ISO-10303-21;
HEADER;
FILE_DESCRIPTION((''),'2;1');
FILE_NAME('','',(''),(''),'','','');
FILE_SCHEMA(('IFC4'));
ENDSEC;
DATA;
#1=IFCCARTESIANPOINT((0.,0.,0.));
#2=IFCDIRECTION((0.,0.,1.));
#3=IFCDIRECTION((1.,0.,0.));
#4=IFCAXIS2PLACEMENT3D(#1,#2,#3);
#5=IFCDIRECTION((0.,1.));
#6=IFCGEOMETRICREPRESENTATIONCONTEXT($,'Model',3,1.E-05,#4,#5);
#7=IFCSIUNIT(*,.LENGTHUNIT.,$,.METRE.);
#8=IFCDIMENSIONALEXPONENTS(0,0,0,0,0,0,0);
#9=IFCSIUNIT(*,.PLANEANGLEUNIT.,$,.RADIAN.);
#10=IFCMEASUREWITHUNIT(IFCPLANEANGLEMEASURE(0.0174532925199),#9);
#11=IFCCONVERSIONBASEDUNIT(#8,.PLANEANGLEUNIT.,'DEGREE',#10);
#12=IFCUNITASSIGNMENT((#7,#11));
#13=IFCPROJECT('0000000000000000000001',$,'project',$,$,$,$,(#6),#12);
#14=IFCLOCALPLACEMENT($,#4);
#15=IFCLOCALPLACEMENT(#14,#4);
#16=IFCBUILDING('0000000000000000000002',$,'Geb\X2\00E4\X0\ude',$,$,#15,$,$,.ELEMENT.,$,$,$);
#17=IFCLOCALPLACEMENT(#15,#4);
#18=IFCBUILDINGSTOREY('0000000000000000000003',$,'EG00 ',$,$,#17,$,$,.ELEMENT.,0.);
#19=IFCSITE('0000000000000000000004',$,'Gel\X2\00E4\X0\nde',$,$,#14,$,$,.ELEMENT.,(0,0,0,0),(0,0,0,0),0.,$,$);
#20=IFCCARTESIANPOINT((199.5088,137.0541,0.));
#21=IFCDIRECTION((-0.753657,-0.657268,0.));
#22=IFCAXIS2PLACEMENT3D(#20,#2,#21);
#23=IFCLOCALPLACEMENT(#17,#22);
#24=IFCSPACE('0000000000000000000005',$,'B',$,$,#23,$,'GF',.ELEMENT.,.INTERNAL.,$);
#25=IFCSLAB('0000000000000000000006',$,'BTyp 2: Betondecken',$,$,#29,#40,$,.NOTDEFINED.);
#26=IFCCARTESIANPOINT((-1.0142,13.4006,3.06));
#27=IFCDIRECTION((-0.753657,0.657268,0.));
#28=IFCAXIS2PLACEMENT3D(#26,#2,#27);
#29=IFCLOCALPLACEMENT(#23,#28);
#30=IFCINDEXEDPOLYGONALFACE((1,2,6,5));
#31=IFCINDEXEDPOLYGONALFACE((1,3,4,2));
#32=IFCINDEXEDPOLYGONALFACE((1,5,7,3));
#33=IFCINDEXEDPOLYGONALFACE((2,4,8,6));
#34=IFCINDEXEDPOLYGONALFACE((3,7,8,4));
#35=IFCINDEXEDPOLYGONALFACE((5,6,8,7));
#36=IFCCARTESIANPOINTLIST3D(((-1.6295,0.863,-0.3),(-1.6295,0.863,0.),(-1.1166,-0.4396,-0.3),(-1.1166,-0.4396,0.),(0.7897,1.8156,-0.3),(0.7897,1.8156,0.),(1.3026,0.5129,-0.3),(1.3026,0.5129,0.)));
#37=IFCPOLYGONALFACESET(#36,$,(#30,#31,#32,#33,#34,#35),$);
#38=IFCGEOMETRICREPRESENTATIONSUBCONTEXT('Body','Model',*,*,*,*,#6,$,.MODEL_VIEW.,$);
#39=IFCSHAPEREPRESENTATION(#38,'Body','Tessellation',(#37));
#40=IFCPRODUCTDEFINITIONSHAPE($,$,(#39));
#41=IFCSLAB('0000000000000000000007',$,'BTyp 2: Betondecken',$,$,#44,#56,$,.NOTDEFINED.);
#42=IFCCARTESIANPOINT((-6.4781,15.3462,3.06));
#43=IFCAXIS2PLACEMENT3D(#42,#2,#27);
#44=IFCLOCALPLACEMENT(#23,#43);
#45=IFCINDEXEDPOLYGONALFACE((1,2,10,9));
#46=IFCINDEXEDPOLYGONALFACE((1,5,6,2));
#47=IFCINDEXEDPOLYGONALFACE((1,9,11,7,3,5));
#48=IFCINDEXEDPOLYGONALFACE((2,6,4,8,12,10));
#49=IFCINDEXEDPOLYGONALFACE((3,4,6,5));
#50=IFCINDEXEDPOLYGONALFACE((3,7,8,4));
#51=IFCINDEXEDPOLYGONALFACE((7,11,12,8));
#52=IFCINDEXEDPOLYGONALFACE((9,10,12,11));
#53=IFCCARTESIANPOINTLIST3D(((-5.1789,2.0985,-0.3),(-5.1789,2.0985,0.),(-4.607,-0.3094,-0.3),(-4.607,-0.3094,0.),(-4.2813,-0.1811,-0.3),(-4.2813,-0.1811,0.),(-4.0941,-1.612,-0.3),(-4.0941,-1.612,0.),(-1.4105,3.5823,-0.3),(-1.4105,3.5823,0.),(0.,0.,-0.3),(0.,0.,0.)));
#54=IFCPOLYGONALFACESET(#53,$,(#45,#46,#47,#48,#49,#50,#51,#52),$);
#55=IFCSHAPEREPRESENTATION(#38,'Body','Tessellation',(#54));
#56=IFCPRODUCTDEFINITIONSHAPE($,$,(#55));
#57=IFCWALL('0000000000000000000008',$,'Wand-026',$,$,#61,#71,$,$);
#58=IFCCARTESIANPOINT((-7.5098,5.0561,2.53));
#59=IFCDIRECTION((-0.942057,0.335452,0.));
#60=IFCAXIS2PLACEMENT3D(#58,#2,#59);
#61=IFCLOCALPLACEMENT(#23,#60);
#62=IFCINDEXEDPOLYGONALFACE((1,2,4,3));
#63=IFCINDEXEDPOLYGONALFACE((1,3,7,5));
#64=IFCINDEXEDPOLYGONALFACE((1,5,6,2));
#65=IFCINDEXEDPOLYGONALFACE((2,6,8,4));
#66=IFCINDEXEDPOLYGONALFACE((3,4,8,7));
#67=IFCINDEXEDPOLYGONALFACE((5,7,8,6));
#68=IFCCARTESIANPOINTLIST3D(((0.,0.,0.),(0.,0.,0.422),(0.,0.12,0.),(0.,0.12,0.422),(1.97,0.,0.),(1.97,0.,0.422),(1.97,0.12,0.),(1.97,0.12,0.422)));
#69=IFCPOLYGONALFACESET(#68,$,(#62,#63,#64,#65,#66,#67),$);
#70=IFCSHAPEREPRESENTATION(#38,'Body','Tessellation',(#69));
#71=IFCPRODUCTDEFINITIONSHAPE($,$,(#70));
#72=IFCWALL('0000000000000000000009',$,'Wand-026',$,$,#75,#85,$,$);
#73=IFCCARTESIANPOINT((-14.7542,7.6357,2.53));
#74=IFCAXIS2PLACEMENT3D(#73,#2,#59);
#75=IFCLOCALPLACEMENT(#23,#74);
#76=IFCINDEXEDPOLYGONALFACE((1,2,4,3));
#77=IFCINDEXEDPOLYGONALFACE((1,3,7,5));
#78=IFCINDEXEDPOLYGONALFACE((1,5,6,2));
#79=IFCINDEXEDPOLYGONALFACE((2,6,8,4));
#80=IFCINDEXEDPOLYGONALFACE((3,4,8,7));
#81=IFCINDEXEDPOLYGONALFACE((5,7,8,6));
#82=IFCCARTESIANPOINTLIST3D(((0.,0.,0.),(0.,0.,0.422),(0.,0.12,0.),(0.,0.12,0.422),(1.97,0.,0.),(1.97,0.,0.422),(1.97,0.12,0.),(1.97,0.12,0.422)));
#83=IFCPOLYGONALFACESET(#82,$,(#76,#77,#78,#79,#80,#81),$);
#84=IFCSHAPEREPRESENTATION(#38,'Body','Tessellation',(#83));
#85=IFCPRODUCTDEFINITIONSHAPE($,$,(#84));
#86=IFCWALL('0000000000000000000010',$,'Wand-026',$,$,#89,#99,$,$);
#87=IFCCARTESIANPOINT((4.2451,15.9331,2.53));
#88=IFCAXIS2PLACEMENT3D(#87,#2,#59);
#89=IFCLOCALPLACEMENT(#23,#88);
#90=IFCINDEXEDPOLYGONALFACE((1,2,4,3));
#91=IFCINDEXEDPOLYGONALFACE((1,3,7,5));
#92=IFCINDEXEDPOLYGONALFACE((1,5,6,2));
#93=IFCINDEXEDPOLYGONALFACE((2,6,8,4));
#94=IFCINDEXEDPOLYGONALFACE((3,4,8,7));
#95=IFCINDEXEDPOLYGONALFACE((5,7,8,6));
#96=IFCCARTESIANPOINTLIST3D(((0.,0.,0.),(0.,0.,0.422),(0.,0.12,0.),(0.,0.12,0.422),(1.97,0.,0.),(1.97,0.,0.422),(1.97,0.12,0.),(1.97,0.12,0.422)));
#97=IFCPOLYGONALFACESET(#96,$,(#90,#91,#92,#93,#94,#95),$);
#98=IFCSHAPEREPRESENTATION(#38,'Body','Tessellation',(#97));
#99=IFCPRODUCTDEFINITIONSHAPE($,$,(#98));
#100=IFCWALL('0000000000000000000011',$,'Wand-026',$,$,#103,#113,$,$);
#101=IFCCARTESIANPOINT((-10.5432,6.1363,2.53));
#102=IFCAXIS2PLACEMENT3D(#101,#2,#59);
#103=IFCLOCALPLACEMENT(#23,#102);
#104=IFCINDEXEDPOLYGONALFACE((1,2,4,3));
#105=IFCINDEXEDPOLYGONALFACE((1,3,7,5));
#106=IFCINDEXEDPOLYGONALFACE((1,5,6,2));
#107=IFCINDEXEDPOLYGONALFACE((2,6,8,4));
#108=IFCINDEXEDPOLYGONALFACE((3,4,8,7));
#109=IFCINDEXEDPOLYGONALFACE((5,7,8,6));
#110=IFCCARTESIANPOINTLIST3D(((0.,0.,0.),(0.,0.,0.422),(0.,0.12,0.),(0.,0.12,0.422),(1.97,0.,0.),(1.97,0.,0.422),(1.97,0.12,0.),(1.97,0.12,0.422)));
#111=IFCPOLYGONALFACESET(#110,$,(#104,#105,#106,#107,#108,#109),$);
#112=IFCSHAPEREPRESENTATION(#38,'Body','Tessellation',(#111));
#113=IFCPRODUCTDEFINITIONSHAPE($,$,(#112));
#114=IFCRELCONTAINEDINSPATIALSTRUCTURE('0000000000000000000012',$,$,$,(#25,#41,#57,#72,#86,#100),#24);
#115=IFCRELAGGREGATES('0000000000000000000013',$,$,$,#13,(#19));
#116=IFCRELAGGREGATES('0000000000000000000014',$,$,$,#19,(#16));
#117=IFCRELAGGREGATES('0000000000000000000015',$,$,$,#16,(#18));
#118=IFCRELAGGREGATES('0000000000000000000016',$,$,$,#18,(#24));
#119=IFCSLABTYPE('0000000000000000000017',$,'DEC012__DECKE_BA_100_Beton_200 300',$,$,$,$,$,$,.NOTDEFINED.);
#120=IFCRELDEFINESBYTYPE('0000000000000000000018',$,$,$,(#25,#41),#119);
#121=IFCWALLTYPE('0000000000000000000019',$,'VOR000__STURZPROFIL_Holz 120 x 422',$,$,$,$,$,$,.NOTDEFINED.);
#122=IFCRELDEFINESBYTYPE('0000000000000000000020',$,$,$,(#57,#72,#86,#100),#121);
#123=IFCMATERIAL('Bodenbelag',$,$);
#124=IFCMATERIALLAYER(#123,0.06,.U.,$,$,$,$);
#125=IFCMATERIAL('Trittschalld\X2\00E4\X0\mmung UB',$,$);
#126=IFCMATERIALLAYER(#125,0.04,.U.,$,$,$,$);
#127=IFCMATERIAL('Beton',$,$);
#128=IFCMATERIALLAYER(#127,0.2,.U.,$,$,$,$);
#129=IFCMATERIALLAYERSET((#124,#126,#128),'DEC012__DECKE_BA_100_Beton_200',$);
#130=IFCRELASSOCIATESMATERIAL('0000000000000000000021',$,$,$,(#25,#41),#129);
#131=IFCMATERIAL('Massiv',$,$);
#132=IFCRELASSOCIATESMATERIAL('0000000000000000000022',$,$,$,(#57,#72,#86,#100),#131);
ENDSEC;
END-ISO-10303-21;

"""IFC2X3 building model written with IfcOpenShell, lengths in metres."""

from ifc_helpers import new_model, entity, si_unit, converted_unit, direction, frame, origin_with_axes, place, context, subcontext, project, spatial, polyline, outline, extrude, material, layer, layer_set, layer_usage, type_object, element, save


model = new_model("IFC2X3")

# Units and contexts
model_context = context("Model", 3, precision=1e-05, world=origin_with_axes(), true_north=direction((0.0, 1.0)))
body_context = subcontext(model_context, "Body", "Model", "MODEL_VIEW")
ifc_project = project(units=[si_unit("LENGTHUNIT", "METRE"), converted_unit("PLANEANGLEUNIT", "DEGREE", entity("IfcPlaneAngleMeasure", 0.0174532925199), si_unit("PLANEANGLEUNIT", "RADIAN"), dimensions=[0, 0, 0, 0, 0, 0, 0])], contexts=[model_context])

# Site, building, storey, space
site_placement = place(None, origin_with_axes())
site = spatial("IfcSite", under=ifc_project, at=site_placement, Name="Gelände", CompositionType="ELEMENT", RefLatitude=(0, 0, 0, 0), RefLongitude=(0, 0, 0, 0), RefElevation=0.0)
building_placement = place(site_placement, origin_with_axes())
building = spatial("IfcBuilding", under=site, at=building_placement, Name="Gebäude", CompositionType="ELEMENT")
storey_placement = place(building_placement, origin_with_axes())
storey = spatial("IfcBuildingStorey", under=building, at=storey_placement, Name="EG00 ", CompositionType="ELEMENT", Elevation=0.0)
space_placement = place(storey_placement, frame((199.5088, 137.0541, 0.0), z_axis=(0.0, 0.0, 1.0), x_axis=(-0.753657, -0.657268, 0.0)))
space = spatial("IfcSpace", under=storey, at=space_placement, Name="B", LongName="GF", CompositionType="ELEMENT", InteriorOrExteriorSpace="INTERNAL")

# Shared definitions
ifc_material_1 = material(Name="Massiv")

# Slabs
ifc_material_2 = material(Name="Bodenbelag")
ifc_layer_1 = layer(ifc_material_2, 0.06, ventilated="UNKNOWN")
ifc_material_3 = material(Name="Trittschalldämmung UB")
ifc_layer_2 = layer(ifc_material_3, 0.04, ventilated="UNKNOWN")
ifc_material_4 = material(Name="Beton")
ifc_layer_3 = layer(ifc_material_4, 0.2, ventilated="UNKNOWN")
ifc_layer_set_1 = layer_set([ifc_layer_1, ifc_layer_2, ifc_layer_3], Name="DEC012__DECKE_BA_100_Beton_200")
ifc_layer_usage_1 = layer_usage(ifc_layer_set_1, "AXIS3", "NEGATIVE", 0.3)
slab_type_1 = type_object("IfcSlabType", Name="DEC012__DECKE_BA_100_Beton_200 300", PredefinedType="NOTDEFINED")
slab_1_placement = place(space_placement, frame((-1.0142, 13.4006, 3.06), z_axis=(0.0, 0.0, 1.0), x_axis=(-0.753657, 0.657268, 0.0)))
element("IfcSlab", 1, at=slab_1_placement, inside=space, type_object=slab_type_1, material=ifc_layer_usage_1, Name="BTyp 2: Betondecken", PredefinedType="NOTDEFINED", context=body_context, shape_type="SweptSolid", body=[
    extrude(outline(polyline([(1.3026, 0.5129), (0.7897, 1.8156), (-1.6295, 0.863), (-1.1166, -0.4396), (1.3026, 0.5129)])), frame((0.0, 0.0, -0.3), z_axis=(0.0, 0.0, 1.0), x_axis=(1.0, 0.0, 0.0)), (0.0, 0.0, 1.0), 0.3),
])
slab_2_placement = place(space_placement, frame((-6.4781, 15.3462, 3.06), z_axis=(0.0, 0.0, 1.0), x_axis=(-0.753657, 0.657268, 0.0)))
element("IfcSlab", 2, at=slab_2_placement, inside=space, type_object=slab_type_1, material=ifc_layer_usage_1, Name="BTyp 2: Betondecken", PredefinedType="NOTDEFINED", context=body_context, shape_type="SweptSolid", body=[
    extrude(outline(polyline([(0.0, 0.0), (-1.4105, 3.5823), (-5.1789, 2.0985), (-4.2813, -0.1811), (-4.607, -0.3094), (-4.0941, -1.612), (0.0, 0.0)])), frame((0.0, 0.0, -0.3), z_axis=(0.0, 0.0, 1.0), x_axis=(1.0, 0.0, 0.0)), (0.0, 0.0, 1.0), 0.3),
])

# Walls
wall_type_1 = type_object("IfcWallType", Name="VOR000__STURZPROFIL_Holz 120 x 422", PredefinedType="NOTDEFINED")
for number, where, z_axis, x_axis, name in (
    (3, (-7.5098, 5.0561, 2.53), (0.0, 0.0, 1.0), (-0.942057, 0.335452, 0.0), "Wand-026"),
    (4, (-14.7542, 7.6357, 2.53), (0.0, 0.0, 1.0), (-0.942057, 0.335452, 0.0), "Wand-026"),
    (5, (4.2451, 15.9331, 2.53), (0.0, 0.0, 1.0), (-0.942057, 0.335452, 0.0), "Wand-026"),
    (6, (-10.5432, 6.1363, 2.53), (0.0, 0.0, 1.0), (-0.942057, 0.335452, 0.0), "Wand-026"),
):
    element("IfcWall", number, at=place(space_placement, frame(where, z_axis=z_axis, x_axis=x_axis)), inside=space, type_object=wall_type_1, material=ifc_material_1, Name=name, context=body_context, shape_type="SweptSolid", body=[
        extrude(outline(polyline([(0.0, 0.0), (0.12, 0.0), (0.12, 0.422), (0.0, 0.422), (0.0, 0.0)])), frame((0.0, 0.0, 0.0), z_axis=(1.0, 0.0, 0.0), x_axis=(0.0, 1.0, 0.0)), (0.0, 0.0, 1.0), 1.97),
    ])

save(model, "model.ifc")
